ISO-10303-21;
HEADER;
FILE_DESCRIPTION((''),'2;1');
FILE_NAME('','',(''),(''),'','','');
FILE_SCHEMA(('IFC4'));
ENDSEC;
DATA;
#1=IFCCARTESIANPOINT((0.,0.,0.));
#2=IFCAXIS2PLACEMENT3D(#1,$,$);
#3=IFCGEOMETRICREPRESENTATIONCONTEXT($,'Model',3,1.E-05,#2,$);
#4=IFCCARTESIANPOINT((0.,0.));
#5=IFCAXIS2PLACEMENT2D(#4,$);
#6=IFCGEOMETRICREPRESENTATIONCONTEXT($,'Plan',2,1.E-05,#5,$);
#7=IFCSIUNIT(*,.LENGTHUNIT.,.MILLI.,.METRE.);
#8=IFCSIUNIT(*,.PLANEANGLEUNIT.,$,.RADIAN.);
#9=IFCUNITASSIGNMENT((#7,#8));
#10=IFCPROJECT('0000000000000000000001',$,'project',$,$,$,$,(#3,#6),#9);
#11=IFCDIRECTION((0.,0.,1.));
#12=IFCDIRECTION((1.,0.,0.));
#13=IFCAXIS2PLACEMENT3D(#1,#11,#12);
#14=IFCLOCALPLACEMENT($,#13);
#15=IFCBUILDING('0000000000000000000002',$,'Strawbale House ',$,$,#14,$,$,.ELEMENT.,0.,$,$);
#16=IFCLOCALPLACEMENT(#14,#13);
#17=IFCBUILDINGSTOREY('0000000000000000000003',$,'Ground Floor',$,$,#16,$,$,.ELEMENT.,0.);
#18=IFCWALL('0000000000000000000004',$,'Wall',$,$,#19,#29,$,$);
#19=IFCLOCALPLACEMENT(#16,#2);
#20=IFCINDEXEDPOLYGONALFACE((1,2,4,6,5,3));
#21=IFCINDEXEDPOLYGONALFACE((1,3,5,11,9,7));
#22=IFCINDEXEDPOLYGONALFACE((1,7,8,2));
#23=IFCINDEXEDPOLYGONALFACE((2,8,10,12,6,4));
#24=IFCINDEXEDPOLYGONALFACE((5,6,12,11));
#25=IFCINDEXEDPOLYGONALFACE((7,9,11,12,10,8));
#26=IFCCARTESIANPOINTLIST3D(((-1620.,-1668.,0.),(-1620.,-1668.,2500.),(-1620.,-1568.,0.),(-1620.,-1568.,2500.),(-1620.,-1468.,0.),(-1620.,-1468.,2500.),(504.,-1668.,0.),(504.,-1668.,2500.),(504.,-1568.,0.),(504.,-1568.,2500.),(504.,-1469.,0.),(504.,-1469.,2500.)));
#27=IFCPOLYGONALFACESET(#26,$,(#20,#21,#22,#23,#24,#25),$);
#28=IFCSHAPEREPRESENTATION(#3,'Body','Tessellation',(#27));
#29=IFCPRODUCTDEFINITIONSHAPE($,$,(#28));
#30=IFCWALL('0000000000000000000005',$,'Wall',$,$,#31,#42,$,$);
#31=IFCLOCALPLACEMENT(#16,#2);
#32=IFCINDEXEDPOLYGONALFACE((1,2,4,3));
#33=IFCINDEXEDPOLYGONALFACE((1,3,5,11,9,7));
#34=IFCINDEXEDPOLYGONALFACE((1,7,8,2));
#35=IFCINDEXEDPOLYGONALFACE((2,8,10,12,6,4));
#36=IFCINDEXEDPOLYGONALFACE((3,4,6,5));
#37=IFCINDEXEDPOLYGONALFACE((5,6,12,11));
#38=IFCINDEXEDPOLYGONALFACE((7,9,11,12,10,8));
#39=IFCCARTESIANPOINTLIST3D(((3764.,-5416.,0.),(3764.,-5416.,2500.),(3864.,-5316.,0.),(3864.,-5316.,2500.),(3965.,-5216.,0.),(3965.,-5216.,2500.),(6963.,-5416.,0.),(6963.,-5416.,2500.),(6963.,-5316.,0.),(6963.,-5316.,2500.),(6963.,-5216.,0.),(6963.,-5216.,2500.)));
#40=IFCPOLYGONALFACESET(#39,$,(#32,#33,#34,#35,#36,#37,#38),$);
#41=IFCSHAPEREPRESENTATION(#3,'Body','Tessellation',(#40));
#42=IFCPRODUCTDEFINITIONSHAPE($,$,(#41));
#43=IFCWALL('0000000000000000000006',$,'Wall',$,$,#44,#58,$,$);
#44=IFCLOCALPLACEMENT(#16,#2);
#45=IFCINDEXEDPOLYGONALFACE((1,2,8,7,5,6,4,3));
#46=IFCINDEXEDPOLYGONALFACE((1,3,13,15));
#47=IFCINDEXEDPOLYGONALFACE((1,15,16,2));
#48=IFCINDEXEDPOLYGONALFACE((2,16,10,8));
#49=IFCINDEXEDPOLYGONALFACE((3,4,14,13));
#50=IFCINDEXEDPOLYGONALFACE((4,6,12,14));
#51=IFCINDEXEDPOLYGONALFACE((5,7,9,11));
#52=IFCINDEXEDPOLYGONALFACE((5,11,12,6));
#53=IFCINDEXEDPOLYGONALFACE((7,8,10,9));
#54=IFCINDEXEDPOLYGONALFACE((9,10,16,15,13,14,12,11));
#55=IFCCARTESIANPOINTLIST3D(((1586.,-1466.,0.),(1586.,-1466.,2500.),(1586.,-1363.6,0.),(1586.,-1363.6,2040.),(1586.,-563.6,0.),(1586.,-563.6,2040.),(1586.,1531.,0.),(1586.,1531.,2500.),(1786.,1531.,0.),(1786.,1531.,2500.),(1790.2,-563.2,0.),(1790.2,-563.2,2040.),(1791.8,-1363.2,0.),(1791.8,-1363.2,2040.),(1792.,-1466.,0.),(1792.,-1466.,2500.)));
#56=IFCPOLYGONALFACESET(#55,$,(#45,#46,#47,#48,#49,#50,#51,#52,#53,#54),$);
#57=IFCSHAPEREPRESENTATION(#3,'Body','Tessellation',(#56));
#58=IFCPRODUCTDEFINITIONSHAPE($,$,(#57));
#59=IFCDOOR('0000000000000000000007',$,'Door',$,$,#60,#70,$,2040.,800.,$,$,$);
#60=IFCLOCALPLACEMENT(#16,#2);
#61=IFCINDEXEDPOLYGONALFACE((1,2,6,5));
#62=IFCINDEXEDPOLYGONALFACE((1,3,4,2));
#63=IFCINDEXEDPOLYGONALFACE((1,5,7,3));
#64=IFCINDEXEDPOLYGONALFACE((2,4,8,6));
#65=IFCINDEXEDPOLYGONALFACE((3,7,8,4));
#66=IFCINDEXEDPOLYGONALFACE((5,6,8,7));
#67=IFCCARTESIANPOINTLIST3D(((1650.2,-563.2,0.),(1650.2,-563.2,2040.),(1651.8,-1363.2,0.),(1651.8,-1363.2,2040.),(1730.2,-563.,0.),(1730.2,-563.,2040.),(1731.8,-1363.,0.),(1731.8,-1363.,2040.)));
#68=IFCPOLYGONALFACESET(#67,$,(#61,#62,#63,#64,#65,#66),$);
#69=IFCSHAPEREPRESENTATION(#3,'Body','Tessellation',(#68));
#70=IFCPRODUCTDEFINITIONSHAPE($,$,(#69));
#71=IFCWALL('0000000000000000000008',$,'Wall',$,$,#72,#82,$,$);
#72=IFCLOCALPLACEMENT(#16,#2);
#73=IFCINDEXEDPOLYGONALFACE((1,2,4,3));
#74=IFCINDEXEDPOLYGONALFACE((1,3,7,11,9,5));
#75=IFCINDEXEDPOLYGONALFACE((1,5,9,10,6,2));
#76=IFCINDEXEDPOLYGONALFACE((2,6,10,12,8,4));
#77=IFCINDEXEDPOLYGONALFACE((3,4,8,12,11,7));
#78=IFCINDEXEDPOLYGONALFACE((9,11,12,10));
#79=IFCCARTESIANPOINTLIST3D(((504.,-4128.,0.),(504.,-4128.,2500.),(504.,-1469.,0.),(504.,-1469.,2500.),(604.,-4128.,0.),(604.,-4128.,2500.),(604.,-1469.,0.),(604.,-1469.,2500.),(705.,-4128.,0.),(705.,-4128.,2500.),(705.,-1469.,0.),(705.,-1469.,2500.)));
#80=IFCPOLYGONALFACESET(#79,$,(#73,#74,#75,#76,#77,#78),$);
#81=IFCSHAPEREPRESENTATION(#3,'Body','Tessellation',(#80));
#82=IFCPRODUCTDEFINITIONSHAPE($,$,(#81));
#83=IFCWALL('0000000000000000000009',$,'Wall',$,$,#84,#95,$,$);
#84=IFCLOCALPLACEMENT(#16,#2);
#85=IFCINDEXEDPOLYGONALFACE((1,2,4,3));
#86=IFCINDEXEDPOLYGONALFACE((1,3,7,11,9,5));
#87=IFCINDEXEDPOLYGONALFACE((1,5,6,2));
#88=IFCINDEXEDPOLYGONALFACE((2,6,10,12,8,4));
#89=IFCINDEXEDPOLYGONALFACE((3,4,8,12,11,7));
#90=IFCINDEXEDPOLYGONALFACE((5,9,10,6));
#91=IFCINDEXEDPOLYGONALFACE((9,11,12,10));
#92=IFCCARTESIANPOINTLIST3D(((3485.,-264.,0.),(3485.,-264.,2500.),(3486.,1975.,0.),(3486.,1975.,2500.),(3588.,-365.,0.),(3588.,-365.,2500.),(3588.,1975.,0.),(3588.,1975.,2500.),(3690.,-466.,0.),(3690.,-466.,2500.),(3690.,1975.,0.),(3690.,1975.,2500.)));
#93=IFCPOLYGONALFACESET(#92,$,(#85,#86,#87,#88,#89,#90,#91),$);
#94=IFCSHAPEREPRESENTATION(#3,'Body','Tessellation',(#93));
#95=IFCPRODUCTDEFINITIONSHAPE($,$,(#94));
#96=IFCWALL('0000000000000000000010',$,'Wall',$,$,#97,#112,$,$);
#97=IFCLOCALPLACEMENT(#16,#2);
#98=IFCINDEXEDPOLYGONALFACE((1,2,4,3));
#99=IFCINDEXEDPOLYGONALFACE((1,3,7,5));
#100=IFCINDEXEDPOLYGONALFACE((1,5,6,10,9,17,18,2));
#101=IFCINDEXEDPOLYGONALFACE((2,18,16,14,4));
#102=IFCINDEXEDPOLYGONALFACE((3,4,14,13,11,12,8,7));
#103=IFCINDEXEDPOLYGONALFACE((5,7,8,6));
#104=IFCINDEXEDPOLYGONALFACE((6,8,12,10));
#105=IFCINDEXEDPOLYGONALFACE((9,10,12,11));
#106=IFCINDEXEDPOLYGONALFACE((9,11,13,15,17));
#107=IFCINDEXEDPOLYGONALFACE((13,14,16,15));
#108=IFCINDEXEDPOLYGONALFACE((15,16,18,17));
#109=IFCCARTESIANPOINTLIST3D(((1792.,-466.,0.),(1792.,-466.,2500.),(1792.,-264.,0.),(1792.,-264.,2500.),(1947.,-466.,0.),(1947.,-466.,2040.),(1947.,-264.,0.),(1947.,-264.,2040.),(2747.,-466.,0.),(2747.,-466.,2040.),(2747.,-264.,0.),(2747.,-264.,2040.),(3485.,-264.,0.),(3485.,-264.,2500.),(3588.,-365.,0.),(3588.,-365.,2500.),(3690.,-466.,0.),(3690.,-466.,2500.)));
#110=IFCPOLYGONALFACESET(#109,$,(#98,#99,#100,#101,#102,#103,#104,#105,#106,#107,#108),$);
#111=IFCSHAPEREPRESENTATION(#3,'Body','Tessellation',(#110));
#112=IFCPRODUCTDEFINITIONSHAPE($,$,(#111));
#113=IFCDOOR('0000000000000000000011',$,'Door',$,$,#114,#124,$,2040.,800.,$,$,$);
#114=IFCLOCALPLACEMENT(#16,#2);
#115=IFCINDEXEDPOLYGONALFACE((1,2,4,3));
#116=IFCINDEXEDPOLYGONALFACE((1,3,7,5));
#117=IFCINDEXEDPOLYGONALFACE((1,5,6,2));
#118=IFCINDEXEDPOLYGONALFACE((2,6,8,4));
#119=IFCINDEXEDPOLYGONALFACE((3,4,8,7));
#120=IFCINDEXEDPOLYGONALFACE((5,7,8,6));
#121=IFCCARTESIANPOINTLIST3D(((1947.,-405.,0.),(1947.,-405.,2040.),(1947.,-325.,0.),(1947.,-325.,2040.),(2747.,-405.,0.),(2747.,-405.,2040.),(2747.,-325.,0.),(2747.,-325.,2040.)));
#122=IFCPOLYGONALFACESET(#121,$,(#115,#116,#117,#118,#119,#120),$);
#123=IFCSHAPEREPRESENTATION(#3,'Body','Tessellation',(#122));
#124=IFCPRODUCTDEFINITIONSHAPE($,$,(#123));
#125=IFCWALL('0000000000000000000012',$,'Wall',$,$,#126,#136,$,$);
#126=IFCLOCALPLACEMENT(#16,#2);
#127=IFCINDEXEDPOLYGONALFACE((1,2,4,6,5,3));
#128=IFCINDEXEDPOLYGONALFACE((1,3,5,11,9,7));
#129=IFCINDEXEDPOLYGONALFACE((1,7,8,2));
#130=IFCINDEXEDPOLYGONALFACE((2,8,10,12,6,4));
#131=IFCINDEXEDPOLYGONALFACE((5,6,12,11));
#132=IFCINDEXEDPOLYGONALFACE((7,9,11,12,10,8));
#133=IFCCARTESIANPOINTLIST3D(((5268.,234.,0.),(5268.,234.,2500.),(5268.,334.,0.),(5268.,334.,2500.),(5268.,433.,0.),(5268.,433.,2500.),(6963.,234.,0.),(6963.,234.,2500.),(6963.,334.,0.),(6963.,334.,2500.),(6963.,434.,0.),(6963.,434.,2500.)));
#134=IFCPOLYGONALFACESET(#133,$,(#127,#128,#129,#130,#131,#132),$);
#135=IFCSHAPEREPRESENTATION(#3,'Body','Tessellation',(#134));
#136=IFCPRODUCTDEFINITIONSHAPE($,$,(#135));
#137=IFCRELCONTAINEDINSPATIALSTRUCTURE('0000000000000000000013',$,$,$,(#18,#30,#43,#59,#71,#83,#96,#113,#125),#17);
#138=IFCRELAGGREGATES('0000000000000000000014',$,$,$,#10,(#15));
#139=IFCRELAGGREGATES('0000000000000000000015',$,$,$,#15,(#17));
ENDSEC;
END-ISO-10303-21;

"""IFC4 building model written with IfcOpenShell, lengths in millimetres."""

from ifc_helpers import new_model, si_unit, frame, origin, origin_with_axes, origin_2d, origin_2d_with_axis, place, context, project, spatial, polyline, rectangle, outline, extrude, element, fill, save


model = new_model("IFC4")

# Units and contexts
model_context = context("Model", 3, precision=1e-05, world=origin())
plan_context = context("Plan", 2, precision=1e-05, world=origin_2d())
ifc_project = project(units=[si_unit("LENGTHUNIT", "METRE", prefix="MILLI"), si_unit("PLANEANGLEUNIT", "RADIAN")], contexts=[model_context, plan_context])

# Building, storey
building_placement = place(None, origin_with_axes())
building = spatial("IfcBuilding", under=ifc_project, at=building_placement, Name="Strawbale House ", CompositionType="ELEMENT", ElevationOfRefHeight=0.0)
storey_placement = place(building_placement, origin_with_axes())
storey = spatial("IfcBuildingStorey", under=building, at=storey_placement, Name="Ground Floor", CompositionType="ELEMENT", Elevation=0.0)

# Walls
wall_1_placement = place(storey_placement, origin_with_axes())
element("IfcWall", 1, at=wall_1_placement, inside=storey, Name="Wall", context=model_context, shape_type="SweptSolid", body=[
    extrude(outline(polyline([(504.0, -1568.0, 0.0), (504.0, -1668.0, 0.0), (-1620.0, -1668.0, 0.0), (-1620.0, -1568.0, 0.0), (-1620.0, -1468.0, 0.0), (504.0, -1469.0, 0.0), (504.0, -1568.0, 0.0)])), origin_with_axes(), (0.0, 0.0, 1.0), 2500.0),
])
wall_2_placement = place(storey_placement, origin_with_axes())
element("IfcWall", 2, at=wall_2_placement, inside=storey, Name="Wall", context=model_context, shape_type="SweptSolid", body=[
    extrude(outline(polyline([(3864.0, -5316.0, 0.0), (3965.0, -5216.0, 0.0), (6963.0, -5216.0, 0.0), (6963.0, -5316.0, 0.0), (6963.0, -5416.0, 0.0), (3764.0, -5416.0, 0.0), (3864.0, -5316.0, 0.0)])), origin_with_axes(), (0.0, 0.0, 1.0), 2500.0),
])

# Wall, opening, door
wall_3_placement = place(storey_placement, origin_with_axes())
wall_3 = element("IfcWall", 3, at=wall_3_placement, inside=storey, Name="Wall", context=model_context, shape_type="SweptSolid", body=[
    extrude(outline(polyline([(1686.0, 1531.0, 0.0), (1786.0, 1531.0, 0.0), (1792.0, -1466.0, 0.0), (1689.0, -1466.0, 0.0), (1586.0, -1466.0, 0.0), (1586.0, 1531.0, 0.0), (1686.0, 1531.0, 0.0)])), origin_with_axes(), (0.0, 0.0, 1.0), 2500.0),
])
opening_1_placement = place(wall_3_placement, frame((1891.0, -963.0, 1020.0), z_axis=(0.0, 0.0, 1.0), x_axis=(1.0, 0.0, 0.0)))
opening_1 = element("IfcOpeningElement", 4, at=opening_1_placement, cuts=wall_3, PredefinedType="OPENING", context=model_context, shape_type="SweptSolid", body=[
    extrude(rectangle(XDim=800.0, YDim=2040.0, at=origin_2d_with_axis()), frame((0.0, 0.0, 0.0), z_axis=(-2997.0, -6.0, 0.0), x_axis=(6.0, -2997.0, 0.0)), (0.0, 0.0, 1.0), 400.0),
])
door_1_placement = place(opening_1_placement, frame((-160.0, 0.0, 0.0), z_axis=(0.0, 0.0, 1.0), x_axis=(1.0, 0.0, 0.0)))
door_1 = element("IfcDoor", 5, at=door_1_placement, inside=storey, Name="Door", OverallHeight=2040.0, OverallWidth=800.0, context=model_context, shape_type="SweptSolid", body=[
    extrude(outline(polyline([(400.0, 1020.0, 0.0), (400.0, -1020.0, 0.0), (-400.0, -1020.0, 0.0), (-400.0, 1020.0, 0.0), (400.0, 1020.0, 0.0)])), frame((0.0, 0.0, 0.0), z_axis=(-2997.0, -6.0, 0.0), x_axis=(6.0, -2997.0, 0.0)), (0.0, 0.0, 1.0), 80.0),
])
fill(opening_1, door_1)

# Walls
wall_4_placement = place(storey_placement, origin_with_axes())
element("IfcWall", 6, at=wall_4_placement, inside=storey, Name="Wall", context=model_context, shape_type="SweptSolid", body=[
    extrude(outline(polyline([(604.0, -4128.0, 0.0), (504.0, -4128.0, 0.0), (504.0, -1469.0, 0.0), (604.0, -1469.0, 0.0), (705.0, -1469.0, 0.0), (705.0, -4128.0, 0.0), (604.0, -4128.0, 0.0)])), origin_with_axes(), (0.0, 0.0, 1.0), 2500.0),
])
wall_5_placement = place(storey_placement, origin_with_axes())
element("IfcWall", 7, at=wall_5_placement, inside=storey, Name="Wall", context=model_context, shape_type="SweptSolid", body=[
    extrude(outline(polyline([(3588.0, -365.0, 0.0), (3485.0, -264.0, 0.0), (3486.0, 1975.0, 0.0), (3588.0, 1975.0, 0.0), (3690.0, 1975.0, 0.0), (3690.0, -466.0, 0.0), (3588.0, -365.0, 0.0)])), origin_with_axes(), (0.0, 0.0, 1.0), 2500.0),
])

# Wall, opening, door
wall_6_placement = place(storey_placement, origin_with_axes())
wall_6 = element("IfcWall", 8, at=wall_6_placement, inside=storey, Name="Wall", context=model_context, shape_type="SweptSolid", body=[
    extrude(outline(polyline([(1792.0, -365.0, 0.0), (1792.0, -264.0, 0.0), (3485.0, -264.0, 0.0), (3588.0, -365.0, 0.0), (3690.0, -466.0, 0.0), (1792.0, -466.0, 0.0), (1792.0, -365.0, 0.0)])), origin_with_axes(), (0.0, 0.0, 1.0), 2500.0),
])
opening_2_placement = place(wall_6_placement, frame((2347.0, -164.0, 1020.0), z_axis=(0.0, 0.0, 1.0), x_axis=(1.0, 0.0, 0.0)))
opening_2 = element("IfcOpeningElement", 9, at=opening_2_placement, cuts=wall_6, PredefinedType="OPENING", context=model_context, shape_type="SweptSolid", body=[
    extrude(rectangle(XDim=800.0, YDim=2040.0, at=origin_2d_with_axis()), frame((0.0, 0.0, 0.0), z_axis=(0.0, -1693.0, 0.0), x_axis=(1693.0, 0.0, 0.0)), (0.0, 0.0, 1.0), 402.0),
])
door_2_placement = place(opening_2_placement, frame((0.0, -161.0, 0.0), z_axis=(0.0, 0.0, 1.0), x_axis=(1.0, 0.0, 0.0)))
door_2 = element("IfcDoor", 10, at=door_2_placement, inside=storey, Name="Door", OverallHeight=2040.0, OverallWidth=800.0, context=model_context, shape_type="SweptSolid", body=[
    extrude(outline(polyline([(400.0, 1020.0, 0.0), (400.0, -1020.0, 0.0), (-400.0, -1020.0, 0.0), (-400.0, 1020.0, 0.0), (400.0, 1020.0, 0.0)])), frame((0.0, 0.0, 0.0), z_axis=(0.0, -1693.0, 0.0), x_axis=(1693.0, 0.0, 0.0)), (0.0, 0.0, 1.0), 80.0),
])
fill(opening_2, door_2)

# Wall
wall_7_placement = place(storey_placement, origin_with_axes())
element("IfcWall", 11, at=wall_7_placement, inside=storey, Name="Wall", context=model_context, shape_type="SweptSolid", body=[
    extrude(outline(polyline([(6963.0, 334.0, 0.0), (6963.0, 234.0, 0.0), (5268.0, 234.0, 0.0), (5268.0, 334.0, 0.0), (5268.0, 433.0, 0.0), (6963.0, 434.0, 0.0), (6963.0, 334.0, 0.0)])), origin_with_axes(), (0.0, 0.0, 1.0), 2500.0),
])

save(model, "model.ifc")
